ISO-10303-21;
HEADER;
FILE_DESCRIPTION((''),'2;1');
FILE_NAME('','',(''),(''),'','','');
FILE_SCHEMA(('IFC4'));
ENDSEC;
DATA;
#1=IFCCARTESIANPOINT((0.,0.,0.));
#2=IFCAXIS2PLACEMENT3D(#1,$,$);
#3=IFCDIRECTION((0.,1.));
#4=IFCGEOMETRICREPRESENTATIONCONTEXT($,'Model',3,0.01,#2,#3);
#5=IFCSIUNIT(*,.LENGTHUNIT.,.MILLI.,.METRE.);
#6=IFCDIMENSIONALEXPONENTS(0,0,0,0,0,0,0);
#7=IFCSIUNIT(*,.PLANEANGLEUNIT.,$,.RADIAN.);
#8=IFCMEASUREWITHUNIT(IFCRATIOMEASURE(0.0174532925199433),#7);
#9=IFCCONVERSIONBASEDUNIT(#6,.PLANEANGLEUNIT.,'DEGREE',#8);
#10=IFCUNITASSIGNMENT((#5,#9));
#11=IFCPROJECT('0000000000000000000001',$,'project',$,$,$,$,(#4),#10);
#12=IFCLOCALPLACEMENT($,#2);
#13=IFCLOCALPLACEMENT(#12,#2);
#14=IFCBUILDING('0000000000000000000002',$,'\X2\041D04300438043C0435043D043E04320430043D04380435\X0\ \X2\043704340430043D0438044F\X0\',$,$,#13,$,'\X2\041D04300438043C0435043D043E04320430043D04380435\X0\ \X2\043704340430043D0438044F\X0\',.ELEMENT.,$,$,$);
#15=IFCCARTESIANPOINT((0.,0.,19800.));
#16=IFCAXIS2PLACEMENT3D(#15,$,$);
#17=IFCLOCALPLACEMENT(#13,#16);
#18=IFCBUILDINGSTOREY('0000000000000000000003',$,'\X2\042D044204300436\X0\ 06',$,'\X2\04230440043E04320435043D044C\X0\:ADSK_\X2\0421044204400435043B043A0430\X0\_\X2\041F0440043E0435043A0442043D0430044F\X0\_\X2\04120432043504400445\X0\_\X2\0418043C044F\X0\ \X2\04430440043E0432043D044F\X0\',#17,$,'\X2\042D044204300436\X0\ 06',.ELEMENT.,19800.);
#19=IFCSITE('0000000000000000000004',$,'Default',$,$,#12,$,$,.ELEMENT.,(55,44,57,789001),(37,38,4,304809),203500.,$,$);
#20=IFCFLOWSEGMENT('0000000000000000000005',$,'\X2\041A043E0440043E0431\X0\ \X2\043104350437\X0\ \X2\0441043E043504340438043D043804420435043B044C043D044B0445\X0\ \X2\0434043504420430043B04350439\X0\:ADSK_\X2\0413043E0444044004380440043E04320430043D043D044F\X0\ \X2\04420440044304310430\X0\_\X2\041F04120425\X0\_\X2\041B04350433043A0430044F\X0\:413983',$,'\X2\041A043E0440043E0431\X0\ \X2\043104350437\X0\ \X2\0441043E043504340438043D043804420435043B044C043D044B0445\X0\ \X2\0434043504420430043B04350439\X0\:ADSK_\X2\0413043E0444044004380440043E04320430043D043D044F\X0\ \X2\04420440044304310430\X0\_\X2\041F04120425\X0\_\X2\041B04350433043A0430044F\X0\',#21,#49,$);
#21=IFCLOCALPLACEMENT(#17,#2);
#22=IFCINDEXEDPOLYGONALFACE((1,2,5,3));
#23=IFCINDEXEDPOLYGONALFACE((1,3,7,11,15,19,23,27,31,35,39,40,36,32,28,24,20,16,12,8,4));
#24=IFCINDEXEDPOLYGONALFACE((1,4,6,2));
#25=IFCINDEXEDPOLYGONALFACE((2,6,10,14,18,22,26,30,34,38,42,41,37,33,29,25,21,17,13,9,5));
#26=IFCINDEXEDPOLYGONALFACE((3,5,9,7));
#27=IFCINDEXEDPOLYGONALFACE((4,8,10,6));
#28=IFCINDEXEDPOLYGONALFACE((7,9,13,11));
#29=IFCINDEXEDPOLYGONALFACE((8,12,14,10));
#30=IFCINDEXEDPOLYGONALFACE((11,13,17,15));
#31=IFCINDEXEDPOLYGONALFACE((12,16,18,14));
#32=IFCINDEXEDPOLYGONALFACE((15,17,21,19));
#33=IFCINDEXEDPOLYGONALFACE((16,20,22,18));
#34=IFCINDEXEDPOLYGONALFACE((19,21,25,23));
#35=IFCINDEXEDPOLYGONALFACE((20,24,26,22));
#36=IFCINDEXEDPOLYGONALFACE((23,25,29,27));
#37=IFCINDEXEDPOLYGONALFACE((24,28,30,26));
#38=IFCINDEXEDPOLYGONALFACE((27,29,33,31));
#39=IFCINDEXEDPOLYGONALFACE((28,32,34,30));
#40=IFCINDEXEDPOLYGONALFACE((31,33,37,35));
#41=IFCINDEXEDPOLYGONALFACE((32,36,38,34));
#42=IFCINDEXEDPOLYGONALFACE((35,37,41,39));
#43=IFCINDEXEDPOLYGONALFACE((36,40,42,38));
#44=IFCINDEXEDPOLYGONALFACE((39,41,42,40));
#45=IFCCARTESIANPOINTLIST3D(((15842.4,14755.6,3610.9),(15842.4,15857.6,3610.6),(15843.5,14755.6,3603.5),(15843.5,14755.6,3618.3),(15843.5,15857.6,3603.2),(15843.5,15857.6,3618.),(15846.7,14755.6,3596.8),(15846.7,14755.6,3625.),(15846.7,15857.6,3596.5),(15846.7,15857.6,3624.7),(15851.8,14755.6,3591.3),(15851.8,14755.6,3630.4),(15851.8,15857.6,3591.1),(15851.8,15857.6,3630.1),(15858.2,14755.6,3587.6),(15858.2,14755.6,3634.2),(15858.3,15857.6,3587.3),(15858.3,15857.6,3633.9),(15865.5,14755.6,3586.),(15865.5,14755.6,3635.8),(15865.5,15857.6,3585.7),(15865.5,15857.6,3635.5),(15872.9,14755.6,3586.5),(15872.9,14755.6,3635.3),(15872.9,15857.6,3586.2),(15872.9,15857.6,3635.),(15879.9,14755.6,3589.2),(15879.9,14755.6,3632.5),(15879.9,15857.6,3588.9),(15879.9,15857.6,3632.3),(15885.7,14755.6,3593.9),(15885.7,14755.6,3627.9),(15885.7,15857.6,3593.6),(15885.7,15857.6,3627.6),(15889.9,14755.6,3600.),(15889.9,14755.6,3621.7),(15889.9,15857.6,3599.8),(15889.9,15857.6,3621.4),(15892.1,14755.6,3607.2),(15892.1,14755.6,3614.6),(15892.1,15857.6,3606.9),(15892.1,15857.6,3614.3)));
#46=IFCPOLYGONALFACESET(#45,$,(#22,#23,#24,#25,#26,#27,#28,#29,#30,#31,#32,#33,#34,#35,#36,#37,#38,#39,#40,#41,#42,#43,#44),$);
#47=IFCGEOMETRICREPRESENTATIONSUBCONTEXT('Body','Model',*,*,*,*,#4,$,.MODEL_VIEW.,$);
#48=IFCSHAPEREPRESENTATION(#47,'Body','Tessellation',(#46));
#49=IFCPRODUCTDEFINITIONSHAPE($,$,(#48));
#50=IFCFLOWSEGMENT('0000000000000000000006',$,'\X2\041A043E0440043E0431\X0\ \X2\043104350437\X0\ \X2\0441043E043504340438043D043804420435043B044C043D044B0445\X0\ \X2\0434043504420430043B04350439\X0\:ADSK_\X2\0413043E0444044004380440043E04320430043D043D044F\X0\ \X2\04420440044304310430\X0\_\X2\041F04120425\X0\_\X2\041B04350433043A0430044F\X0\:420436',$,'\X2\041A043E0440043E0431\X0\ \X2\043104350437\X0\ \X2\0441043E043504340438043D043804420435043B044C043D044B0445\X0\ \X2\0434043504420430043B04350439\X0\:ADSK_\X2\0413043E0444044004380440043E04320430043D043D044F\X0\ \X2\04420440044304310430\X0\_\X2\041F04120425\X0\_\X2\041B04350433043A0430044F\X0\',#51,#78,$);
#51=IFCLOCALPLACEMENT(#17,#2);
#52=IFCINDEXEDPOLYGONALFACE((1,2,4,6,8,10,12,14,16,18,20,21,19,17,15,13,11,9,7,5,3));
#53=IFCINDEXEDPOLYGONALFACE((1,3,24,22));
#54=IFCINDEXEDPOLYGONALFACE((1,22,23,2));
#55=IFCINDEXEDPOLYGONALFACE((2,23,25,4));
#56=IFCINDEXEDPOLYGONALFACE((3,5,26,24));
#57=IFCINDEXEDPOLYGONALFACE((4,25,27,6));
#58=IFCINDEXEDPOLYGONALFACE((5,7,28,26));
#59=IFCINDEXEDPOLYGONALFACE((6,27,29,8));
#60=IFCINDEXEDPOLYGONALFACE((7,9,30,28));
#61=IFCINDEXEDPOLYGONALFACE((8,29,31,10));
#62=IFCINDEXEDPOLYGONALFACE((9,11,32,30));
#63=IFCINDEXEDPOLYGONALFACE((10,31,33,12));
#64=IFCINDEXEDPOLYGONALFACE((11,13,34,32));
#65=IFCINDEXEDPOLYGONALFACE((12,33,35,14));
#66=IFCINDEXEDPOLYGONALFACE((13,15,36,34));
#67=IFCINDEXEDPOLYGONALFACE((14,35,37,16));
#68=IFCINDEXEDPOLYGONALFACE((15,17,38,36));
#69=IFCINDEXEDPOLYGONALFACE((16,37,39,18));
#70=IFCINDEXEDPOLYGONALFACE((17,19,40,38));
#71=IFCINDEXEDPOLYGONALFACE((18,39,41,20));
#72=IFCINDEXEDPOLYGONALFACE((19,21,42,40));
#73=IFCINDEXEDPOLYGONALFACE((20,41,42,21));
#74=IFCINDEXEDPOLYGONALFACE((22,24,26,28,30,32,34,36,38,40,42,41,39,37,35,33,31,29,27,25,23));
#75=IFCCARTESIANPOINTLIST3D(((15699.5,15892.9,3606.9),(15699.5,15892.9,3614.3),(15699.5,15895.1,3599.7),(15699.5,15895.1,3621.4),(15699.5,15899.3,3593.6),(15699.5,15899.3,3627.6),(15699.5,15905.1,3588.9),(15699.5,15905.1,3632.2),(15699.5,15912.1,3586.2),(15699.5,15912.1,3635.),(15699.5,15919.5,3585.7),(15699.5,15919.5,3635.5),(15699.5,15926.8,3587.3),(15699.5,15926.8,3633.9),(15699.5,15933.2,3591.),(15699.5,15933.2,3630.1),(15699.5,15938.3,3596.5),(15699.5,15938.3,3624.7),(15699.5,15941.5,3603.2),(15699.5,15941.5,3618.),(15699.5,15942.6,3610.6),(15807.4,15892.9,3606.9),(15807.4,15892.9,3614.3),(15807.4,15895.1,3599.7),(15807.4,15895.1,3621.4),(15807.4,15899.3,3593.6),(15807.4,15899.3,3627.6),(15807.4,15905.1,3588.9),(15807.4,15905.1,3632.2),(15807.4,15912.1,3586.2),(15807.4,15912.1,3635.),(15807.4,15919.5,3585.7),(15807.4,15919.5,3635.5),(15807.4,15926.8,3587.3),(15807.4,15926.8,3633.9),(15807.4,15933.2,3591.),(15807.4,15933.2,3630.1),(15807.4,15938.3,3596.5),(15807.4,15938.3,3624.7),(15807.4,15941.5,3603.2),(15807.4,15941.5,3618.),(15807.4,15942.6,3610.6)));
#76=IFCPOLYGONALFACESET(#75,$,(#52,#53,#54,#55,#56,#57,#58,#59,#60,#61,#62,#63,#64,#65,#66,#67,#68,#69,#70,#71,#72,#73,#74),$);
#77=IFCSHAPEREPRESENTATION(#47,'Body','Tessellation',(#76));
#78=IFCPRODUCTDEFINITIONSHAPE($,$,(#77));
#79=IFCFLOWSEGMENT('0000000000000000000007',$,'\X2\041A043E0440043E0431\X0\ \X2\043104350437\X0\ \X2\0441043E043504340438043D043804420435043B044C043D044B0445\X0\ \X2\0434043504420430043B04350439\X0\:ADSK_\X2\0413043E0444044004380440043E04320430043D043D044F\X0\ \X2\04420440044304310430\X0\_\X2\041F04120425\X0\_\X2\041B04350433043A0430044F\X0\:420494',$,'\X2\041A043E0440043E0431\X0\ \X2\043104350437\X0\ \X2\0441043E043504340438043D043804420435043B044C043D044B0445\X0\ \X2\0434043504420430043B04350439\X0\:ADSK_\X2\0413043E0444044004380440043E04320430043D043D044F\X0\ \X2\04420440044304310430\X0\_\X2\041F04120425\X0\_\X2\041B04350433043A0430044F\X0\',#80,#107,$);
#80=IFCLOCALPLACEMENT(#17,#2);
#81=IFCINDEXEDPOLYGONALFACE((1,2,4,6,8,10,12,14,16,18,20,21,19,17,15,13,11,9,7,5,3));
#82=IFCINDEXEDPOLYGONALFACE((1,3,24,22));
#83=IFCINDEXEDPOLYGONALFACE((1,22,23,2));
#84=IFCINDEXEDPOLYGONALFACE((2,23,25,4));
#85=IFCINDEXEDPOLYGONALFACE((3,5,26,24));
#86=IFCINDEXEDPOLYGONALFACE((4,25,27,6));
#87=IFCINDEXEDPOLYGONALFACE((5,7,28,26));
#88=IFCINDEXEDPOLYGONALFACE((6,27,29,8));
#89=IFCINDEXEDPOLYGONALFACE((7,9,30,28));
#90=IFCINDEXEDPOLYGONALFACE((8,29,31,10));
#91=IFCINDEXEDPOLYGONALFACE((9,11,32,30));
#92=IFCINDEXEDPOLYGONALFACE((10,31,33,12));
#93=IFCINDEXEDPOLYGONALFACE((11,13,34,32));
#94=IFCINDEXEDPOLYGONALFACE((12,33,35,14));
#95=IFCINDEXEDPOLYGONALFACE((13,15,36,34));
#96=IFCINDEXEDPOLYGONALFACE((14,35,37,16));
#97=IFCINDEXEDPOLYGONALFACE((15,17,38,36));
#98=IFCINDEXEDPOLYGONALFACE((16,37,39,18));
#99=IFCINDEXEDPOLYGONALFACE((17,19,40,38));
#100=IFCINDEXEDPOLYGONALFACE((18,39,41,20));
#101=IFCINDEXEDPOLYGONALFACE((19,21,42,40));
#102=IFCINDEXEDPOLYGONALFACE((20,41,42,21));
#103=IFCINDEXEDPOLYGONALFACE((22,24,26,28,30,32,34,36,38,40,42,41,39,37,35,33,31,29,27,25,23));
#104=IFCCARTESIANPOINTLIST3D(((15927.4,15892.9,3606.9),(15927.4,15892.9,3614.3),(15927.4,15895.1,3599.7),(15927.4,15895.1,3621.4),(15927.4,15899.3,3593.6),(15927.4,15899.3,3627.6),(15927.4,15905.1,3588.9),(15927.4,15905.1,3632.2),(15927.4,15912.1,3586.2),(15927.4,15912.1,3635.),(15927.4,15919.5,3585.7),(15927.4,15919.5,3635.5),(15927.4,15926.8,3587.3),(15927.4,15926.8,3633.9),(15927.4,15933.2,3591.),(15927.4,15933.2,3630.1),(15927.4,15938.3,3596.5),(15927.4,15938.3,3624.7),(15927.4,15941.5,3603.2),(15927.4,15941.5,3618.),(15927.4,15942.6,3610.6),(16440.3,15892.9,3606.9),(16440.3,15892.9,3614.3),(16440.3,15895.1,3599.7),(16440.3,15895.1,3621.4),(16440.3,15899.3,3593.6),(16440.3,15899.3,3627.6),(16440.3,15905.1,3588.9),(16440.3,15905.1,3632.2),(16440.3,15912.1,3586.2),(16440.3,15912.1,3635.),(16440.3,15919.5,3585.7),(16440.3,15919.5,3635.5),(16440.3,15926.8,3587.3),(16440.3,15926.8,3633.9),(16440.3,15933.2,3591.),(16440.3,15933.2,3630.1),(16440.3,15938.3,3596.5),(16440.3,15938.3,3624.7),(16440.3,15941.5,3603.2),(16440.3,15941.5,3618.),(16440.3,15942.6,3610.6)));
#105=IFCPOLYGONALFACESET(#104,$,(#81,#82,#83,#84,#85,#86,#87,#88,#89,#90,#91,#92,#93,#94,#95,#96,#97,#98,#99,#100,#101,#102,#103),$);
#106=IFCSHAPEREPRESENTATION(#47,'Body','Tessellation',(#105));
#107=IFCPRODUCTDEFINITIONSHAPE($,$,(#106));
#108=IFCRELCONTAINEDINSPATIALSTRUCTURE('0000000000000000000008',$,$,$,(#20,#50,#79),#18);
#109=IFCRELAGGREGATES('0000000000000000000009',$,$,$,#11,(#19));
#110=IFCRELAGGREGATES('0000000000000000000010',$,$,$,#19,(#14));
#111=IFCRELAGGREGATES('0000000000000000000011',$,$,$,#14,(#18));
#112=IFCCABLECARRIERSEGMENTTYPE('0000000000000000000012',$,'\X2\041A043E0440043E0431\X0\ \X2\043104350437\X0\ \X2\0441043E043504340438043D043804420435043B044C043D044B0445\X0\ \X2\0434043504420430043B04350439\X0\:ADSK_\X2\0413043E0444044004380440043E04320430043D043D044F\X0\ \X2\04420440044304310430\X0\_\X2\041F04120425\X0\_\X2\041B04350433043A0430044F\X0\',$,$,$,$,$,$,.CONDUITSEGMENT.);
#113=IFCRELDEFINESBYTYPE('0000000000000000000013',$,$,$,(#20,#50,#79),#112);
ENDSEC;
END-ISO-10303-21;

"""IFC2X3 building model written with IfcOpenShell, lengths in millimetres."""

from ifc_helpers import new_model, entity, si_unit, converted_unit, direction, frame, frame_2d, origin, place, context, subcontext, project, spatial, circle, extrude, type_object, element, save


model = new_model("IFC2X3")

# Units and contexts
model_context = context("Model", 3, precision=0.01, world=origin(), true_north=direction((0.0, 1.0)))
body_context = subcontext(model_context, "Body", "Model", "MODEL_VIEW")
ifc_project = project(units=[si_unit("LENGTHUNIT", "METRE", prefix="MILLI"), converted_unit("PLANEANGLEUNIT", "DEGREE", entity("IfcRatioMeasure", 0.0174532925199433), si_unit("PLANEANGLEUNIT", "RADIAN"), dimensions=[0, 0, 0, 0, 0, 0, 0])], contexts=[model_context])

# Site, building, storey
site_placement = place(None, frame((0.0, 0.0, 0.0)))
site = spatial("IfcSite", under=ifc_project, at=site_placement, Name="Default", CompositionType="ELEMENT", RefLatitude=(55, 44, 57, 789001), RefLongitude=(37, 38, 4, 304809), RefElevation=203500.0)
building_placement = place(site_placement, origin())
building = spatial("IfcBuilding", under=site, at=building_placement, Name="Наименование здания", LongName="Наименование здания", CompositionType="ELEMENT")
storey_placement = place(building_placement, frame((0.0, 0.0, 19800.0)))
storey = spatial("IfcBuildingStorey", under=building, at=storey_placement, Name="Этаж 06", ObjectType="Уровень:ADSK_Стрелка_Проектная_Вверх_Имя уровня", LongName="Этаж 06", CompositionType="ELEMENT", Elevation=19800.0)

# Flow segments
cable_carrier_segment_type = type_object("IfcCableCarrierSegmentType", Name="Короб без соединительных деталей:ADSK_Гофрировання труба_ПВХ_Легкая", PredefinedType="CONDUITSEGMENT")
flow_segment_1_placement = place(storey_placement, frame((15840.8, 14755.6, 3584.0)))
element("IfcFlowSegment", 1, at=flow_segment_1_placement, inside=storey, type_object=cable_carrier_segment_type, Name="Короб без соединительных деталей:ADSK_Гофрировання труба_ПВХ_Легкая:413983", ObjectType="Короб без соединительных деталей:ADSK_Гофрировання труба_ПВХ_Легкая", context=body_context, shape_type="SweptSolid", body=[
    extrude(circle(Radius=25.0, at=frame_2d((0.0, 0.0), x_axis=(1.0, 0.0))), frame((26.6, 0.0, 26.9), z_axis=(0.000002, 1.0, -0.000267), x_axis=(-1.0, 0.000002, 0.0)), (0.0, 0.0, 1.0), 1102.0),
])
flow_segment_2_placement = place(storey_placement, frame((15699.5, 15891.0, 3584.0)))
element("IfcFlowSegment", 2, at=flow_segment_2_placement, inside=storey, type_object=cable_carrier_segment_type, Name="Короб без соединительных деталей:ADSK_Гофрировання труба_ПВХ_Легкая:420436", ObjectType="Короб без соединительных деталей:ADSK_Гофрировання труба_ПВХ_Легкая", context=body_context, shape_type="SweptSolid", body=[
    extrude(circle(Radius=25.0, at=frame_2d((0.0, 0.0), x_axis=(1.0, 0.0))), frame((0.0, 26.6, 26.6), z_axis=(1.0, 0.000001, 0.0), x_axis=(-0.000001, 1.0, 0.0)), (0.0, 0.0, 1.0), 107.9),
])
flow_segment_3_placement = place(storey_placement, frame((15927.4, 15891.0, 3584.0)))
element("IfcFlowSegment", 3, at=flow_segment_3_placement, inside=storey, type_object=cable_carrier_segment_type, Name="Короб без соединительных деталей:ADSK_Гофрировання труба_ПВХ_Легкая:420494", ObjectType="Короб без соединительных деталей:ADSK_Гофрировання труба_ПВХ_Легкая", context=body_context, shape_type="SweptSolid", body=[
    extrude(circle(Radius=25.0, at=frame_2d((0.0, 0.0), x_axis=(1.0, 0.0))), frame((0.0, 26.6, 26.6), z_axis=(1.0, 0.000001, 0.0), x_axis=(-0.000001, 1.0, 0.0)), (0.0, 0.0, 1.0), 512.9),
])

save(model, "model.ifc")
